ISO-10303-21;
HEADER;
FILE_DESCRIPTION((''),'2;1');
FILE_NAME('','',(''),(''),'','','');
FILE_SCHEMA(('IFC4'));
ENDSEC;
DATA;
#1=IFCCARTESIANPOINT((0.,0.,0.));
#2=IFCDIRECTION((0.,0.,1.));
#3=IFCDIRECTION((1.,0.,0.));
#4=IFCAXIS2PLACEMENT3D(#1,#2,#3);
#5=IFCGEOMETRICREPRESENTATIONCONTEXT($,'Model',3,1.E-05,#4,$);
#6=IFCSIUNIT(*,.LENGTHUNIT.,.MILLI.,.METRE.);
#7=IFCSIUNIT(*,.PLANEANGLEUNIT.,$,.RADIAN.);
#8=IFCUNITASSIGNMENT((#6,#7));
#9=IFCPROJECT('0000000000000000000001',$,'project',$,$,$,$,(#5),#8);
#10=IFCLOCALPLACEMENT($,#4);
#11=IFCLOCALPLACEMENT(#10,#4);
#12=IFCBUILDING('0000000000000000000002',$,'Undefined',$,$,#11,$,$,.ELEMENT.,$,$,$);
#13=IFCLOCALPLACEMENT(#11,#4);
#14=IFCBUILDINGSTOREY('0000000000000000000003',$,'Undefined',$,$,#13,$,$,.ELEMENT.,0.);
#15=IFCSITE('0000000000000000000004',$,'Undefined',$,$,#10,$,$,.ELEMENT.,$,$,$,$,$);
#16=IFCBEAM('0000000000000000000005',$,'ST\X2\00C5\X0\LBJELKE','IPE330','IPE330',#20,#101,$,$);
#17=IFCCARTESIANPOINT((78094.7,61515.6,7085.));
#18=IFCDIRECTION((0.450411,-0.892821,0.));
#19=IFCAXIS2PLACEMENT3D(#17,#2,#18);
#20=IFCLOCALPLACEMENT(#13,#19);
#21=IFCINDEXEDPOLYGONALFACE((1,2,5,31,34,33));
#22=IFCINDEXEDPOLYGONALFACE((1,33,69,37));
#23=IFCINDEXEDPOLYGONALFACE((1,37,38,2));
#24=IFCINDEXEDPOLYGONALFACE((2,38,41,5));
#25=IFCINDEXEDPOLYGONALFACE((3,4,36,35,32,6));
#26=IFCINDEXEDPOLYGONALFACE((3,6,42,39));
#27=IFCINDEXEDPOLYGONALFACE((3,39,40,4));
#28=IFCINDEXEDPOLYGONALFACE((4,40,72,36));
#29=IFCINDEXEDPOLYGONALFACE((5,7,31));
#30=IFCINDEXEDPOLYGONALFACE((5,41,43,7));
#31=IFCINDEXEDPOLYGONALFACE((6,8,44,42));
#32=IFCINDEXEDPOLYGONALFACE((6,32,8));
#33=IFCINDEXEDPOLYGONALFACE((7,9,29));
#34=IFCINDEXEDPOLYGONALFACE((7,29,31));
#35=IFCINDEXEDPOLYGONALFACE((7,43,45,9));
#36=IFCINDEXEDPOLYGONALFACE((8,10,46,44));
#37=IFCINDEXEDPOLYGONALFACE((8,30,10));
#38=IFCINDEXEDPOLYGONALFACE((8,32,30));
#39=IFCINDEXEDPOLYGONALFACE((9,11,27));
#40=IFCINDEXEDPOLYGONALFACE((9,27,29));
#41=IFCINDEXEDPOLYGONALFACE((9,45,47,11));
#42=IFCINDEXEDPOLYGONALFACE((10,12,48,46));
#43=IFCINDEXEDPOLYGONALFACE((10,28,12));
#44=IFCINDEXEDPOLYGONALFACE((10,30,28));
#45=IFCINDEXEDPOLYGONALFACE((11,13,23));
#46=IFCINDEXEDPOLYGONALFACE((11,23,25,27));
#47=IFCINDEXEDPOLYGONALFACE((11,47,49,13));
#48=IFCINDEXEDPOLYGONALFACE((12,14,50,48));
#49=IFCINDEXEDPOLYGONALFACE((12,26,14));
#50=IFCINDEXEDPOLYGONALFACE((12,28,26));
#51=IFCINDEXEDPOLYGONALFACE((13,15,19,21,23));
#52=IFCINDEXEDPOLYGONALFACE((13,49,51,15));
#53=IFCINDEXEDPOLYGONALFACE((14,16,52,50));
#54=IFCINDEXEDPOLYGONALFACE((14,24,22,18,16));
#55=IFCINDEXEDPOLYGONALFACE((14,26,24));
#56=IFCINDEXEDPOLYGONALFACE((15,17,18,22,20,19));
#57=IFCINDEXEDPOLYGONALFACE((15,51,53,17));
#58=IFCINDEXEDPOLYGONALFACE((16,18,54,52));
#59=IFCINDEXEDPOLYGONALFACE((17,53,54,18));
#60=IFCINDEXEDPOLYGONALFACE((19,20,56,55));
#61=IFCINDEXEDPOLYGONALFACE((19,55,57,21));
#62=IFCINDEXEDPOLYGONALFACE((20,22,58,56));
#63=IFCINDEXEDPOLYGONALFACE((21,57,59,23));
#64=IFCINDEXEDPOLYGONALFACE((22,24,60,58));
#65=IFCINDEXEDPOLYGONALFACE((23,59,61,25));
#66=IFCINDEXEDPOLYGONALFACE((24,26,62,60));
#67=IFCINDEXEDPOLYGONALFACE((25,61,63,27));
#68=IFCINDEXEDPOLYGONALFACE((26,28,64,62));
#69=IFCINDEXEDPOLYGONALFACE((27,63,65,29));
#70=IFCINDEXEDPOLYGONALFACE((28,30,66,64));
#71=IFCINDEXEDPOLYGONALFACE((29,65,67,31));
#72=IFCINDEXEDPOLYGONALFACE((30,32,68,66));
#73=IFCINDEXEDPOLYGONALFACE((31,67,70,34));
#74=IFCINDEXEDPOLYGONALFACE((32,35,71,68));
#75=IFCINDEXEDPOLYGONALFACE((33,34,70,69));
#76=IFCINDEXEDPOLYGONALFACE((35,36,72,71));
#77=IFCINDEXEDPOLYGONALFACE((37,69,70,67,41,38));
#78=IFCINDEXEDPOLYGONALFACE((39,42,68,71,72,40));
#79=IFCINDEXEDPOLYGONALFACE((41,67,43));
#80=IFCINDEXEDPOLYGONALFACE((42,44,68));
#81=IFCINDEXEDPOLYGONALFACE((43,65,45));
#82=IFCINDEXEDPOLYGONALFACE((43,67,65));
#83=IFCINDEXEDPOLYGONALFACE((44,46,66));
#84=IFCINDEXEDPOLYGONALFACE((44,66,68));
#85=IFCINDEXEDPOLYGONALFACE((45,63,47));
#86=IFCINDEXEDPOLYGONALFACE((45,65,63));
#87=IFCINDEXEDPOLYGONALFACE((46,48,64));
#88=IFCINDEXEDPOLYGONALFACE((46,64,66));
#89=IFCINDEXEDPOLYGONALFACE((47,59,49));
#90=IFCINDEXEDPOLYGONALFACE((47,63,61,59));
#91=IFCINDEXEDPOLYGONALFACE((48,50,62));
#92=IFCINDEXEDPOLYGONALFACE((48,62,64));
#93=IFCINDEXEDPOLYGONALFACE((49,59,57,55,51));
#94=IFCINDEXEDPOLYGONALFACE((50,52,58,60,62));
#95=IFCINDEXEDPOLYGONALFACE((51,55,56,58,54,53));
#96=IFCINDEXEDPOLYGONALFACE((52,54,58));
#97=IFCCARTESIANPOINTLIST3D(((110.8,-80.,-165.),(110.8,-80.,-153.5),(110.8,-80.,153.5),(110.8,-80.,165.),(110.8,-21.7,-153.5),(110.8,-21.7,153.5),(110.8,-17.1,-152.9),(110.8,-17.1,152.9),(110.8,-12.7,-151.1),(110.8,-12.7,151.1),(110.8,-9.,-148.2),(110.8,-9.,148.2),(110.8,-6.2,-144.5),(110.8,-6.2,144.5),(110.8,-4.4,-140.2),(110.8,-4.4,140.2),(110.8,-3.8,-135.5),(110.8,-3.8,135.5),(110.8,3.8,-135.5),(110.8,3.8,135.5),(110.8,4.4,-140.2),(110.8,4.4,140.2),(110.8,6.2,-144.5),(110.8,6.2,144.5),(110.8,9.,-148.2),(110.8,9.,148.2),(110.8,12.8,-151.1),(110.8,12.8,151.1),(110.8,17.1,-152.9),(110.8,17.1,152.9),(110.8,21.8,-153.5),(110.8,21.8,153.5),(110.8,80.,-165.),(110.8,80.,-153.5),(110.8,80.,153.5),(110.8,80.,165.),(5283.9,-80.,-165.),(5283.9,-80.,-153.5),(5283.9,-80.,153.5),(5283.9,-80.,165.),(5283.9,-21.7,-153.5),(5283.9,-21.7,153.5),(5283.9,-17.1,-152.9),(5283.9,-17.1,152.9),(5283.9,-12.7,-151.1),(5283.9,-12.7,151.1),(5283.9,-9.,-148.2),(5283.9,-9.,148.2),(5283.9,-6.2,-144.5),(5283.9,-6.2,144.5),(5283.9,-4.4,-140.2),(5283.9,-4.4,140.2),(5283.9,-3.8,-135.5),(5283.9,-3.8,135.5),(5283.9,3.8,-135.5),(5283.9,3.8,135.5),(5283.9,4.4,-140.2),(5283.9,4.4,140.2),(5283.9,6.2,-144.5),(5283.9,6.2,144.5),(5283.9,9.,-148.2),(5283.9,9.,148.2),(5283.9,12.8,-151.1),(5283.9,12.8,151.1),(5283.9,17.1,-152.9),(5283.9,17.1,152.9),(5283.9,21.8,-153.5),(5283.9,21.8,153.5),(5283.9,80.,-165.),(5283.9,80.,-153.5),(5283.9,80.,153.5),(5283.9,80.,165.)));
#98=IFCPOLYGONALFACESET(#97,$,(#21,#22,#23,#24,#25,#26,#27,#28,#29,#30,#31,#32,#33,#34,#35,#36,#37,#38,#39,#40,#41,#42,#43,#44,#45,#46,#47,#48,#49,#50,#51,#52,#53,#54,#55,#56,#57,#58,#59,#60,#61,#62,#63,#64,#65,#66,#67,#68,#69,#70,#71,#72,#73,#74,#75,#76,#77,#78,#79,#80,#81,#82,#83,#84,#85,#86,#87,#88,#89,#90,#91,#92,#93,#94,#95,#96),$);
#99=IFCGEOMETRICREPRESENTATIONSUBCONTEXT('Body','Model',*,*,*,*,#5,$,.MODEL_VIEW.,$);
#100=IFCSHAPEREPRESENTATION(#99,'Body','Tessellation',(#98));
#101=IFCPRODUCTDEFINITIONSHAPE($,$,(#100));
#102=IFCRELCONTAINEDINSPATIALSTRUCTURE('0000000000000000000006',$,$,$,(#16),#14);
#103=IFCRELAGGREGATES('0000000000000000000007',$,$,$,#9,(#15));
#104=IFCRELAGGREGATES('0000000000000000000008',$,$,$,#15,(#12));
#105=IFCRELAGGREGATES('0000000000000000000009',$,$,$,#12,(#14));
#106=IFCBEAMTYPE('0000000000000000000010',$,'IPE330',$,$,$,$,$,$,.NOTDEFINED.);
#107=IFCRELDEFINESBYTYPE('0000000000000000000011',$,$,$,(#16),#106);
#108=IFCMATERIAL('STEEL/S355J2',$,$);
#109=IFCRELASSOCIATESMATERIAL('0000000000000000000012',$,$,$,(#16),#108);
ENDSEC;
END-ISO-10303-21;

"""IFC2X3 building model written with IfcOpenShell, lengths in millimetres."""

from ifc_helpers import new_model, si_unit, frame, origin_with_axes, origin_2d_with_axis, place, context, subcontext, project, spatial, i_section, extrude, clip, halfspace, material, type_object, element, save


model = new_model("IFC2X3")

# Units and contexts
model_context = context("Model", 3, precision=1e-05, world=origin_with_axes())
body_context = subcontext(model_context, "Body", "Model", "MODEL_VIEW")
ifc_project = project(units=[si_unit("LENGTHUNIT", "METRE", prefix="MILLI"), si_unit("PLANEANGLEUNIT", "RADIAN")], contexts=[model_context])

# Site, building, storey
site_placement = place(None, origin_with_axes())
site = spatial("IfcSite", under=ifc_project, at=site_placement, Name="Undefined", CompositionType="ELEMENT")
building_placement = place(site_placement, origin_with_axes())
building = spatial("IfcBuilding", under=site, at=building_placement, Name="Undefined", CompositionType="ELEMENT")
storey_placement = place(building_placement, origin_with_axes())
storey = spatial("IfcBuildingStorey", under=building, at=storey_placement, Name="Undefined", CompositionType="ELEMENT", Elevation=0.0)

# Shared definitions
ifc_material_1 = material(Name="STEEL/S355J2")

# Beam
beam_type_1 = type_object("IfcBeamType", Name="IPE330", PredefinedType="NOTDEFINED")
beam_1_placement = place(storey_placement, frame((78094.7, 61515.6, 7085.0), z_axis=(0.0, 0.0, 1.0), x_axis=(0.450411, -0.892821, 0.0)))
element("IfcBeam", 1, at=beam_1_placement, inside=storey, type_object=beam_type_1, material=ifc_material_1, Name="STÅLBJELKE", Description="IPE330", ObjectType="IPE330", context=body_context, shape_type="Clipping", body=[
    clip(clip(extrude(i_section(OverallWidth=160.0, OverallDepth=330.0, WebThickness=7.5, FlangeThickness=11.5, FilletRadius=18.0, at=origin_2d_with_axis()), frame((5413.9, 0.0, 0.0), z_axis=(-1.0, 0.0, 0.0), x_axis=(0.0, -1.0, 0.0)), (0.0, 0.0, 1.0), 5433.1), halfspace(frame((5283.9, 0.0, 265.0), z_axis=(1.0, 0.000115, 0.0), x_axis=(-0.000115, 1.0, 0.0)), False)), halfspace(frame((110.8, 0.2, 265.0), z_axis=(1.0, 0.000115, 0.0), x_axis=(-0.000115, 1.0, 0.0)), True)),
])

save(model, "model.ifc")
